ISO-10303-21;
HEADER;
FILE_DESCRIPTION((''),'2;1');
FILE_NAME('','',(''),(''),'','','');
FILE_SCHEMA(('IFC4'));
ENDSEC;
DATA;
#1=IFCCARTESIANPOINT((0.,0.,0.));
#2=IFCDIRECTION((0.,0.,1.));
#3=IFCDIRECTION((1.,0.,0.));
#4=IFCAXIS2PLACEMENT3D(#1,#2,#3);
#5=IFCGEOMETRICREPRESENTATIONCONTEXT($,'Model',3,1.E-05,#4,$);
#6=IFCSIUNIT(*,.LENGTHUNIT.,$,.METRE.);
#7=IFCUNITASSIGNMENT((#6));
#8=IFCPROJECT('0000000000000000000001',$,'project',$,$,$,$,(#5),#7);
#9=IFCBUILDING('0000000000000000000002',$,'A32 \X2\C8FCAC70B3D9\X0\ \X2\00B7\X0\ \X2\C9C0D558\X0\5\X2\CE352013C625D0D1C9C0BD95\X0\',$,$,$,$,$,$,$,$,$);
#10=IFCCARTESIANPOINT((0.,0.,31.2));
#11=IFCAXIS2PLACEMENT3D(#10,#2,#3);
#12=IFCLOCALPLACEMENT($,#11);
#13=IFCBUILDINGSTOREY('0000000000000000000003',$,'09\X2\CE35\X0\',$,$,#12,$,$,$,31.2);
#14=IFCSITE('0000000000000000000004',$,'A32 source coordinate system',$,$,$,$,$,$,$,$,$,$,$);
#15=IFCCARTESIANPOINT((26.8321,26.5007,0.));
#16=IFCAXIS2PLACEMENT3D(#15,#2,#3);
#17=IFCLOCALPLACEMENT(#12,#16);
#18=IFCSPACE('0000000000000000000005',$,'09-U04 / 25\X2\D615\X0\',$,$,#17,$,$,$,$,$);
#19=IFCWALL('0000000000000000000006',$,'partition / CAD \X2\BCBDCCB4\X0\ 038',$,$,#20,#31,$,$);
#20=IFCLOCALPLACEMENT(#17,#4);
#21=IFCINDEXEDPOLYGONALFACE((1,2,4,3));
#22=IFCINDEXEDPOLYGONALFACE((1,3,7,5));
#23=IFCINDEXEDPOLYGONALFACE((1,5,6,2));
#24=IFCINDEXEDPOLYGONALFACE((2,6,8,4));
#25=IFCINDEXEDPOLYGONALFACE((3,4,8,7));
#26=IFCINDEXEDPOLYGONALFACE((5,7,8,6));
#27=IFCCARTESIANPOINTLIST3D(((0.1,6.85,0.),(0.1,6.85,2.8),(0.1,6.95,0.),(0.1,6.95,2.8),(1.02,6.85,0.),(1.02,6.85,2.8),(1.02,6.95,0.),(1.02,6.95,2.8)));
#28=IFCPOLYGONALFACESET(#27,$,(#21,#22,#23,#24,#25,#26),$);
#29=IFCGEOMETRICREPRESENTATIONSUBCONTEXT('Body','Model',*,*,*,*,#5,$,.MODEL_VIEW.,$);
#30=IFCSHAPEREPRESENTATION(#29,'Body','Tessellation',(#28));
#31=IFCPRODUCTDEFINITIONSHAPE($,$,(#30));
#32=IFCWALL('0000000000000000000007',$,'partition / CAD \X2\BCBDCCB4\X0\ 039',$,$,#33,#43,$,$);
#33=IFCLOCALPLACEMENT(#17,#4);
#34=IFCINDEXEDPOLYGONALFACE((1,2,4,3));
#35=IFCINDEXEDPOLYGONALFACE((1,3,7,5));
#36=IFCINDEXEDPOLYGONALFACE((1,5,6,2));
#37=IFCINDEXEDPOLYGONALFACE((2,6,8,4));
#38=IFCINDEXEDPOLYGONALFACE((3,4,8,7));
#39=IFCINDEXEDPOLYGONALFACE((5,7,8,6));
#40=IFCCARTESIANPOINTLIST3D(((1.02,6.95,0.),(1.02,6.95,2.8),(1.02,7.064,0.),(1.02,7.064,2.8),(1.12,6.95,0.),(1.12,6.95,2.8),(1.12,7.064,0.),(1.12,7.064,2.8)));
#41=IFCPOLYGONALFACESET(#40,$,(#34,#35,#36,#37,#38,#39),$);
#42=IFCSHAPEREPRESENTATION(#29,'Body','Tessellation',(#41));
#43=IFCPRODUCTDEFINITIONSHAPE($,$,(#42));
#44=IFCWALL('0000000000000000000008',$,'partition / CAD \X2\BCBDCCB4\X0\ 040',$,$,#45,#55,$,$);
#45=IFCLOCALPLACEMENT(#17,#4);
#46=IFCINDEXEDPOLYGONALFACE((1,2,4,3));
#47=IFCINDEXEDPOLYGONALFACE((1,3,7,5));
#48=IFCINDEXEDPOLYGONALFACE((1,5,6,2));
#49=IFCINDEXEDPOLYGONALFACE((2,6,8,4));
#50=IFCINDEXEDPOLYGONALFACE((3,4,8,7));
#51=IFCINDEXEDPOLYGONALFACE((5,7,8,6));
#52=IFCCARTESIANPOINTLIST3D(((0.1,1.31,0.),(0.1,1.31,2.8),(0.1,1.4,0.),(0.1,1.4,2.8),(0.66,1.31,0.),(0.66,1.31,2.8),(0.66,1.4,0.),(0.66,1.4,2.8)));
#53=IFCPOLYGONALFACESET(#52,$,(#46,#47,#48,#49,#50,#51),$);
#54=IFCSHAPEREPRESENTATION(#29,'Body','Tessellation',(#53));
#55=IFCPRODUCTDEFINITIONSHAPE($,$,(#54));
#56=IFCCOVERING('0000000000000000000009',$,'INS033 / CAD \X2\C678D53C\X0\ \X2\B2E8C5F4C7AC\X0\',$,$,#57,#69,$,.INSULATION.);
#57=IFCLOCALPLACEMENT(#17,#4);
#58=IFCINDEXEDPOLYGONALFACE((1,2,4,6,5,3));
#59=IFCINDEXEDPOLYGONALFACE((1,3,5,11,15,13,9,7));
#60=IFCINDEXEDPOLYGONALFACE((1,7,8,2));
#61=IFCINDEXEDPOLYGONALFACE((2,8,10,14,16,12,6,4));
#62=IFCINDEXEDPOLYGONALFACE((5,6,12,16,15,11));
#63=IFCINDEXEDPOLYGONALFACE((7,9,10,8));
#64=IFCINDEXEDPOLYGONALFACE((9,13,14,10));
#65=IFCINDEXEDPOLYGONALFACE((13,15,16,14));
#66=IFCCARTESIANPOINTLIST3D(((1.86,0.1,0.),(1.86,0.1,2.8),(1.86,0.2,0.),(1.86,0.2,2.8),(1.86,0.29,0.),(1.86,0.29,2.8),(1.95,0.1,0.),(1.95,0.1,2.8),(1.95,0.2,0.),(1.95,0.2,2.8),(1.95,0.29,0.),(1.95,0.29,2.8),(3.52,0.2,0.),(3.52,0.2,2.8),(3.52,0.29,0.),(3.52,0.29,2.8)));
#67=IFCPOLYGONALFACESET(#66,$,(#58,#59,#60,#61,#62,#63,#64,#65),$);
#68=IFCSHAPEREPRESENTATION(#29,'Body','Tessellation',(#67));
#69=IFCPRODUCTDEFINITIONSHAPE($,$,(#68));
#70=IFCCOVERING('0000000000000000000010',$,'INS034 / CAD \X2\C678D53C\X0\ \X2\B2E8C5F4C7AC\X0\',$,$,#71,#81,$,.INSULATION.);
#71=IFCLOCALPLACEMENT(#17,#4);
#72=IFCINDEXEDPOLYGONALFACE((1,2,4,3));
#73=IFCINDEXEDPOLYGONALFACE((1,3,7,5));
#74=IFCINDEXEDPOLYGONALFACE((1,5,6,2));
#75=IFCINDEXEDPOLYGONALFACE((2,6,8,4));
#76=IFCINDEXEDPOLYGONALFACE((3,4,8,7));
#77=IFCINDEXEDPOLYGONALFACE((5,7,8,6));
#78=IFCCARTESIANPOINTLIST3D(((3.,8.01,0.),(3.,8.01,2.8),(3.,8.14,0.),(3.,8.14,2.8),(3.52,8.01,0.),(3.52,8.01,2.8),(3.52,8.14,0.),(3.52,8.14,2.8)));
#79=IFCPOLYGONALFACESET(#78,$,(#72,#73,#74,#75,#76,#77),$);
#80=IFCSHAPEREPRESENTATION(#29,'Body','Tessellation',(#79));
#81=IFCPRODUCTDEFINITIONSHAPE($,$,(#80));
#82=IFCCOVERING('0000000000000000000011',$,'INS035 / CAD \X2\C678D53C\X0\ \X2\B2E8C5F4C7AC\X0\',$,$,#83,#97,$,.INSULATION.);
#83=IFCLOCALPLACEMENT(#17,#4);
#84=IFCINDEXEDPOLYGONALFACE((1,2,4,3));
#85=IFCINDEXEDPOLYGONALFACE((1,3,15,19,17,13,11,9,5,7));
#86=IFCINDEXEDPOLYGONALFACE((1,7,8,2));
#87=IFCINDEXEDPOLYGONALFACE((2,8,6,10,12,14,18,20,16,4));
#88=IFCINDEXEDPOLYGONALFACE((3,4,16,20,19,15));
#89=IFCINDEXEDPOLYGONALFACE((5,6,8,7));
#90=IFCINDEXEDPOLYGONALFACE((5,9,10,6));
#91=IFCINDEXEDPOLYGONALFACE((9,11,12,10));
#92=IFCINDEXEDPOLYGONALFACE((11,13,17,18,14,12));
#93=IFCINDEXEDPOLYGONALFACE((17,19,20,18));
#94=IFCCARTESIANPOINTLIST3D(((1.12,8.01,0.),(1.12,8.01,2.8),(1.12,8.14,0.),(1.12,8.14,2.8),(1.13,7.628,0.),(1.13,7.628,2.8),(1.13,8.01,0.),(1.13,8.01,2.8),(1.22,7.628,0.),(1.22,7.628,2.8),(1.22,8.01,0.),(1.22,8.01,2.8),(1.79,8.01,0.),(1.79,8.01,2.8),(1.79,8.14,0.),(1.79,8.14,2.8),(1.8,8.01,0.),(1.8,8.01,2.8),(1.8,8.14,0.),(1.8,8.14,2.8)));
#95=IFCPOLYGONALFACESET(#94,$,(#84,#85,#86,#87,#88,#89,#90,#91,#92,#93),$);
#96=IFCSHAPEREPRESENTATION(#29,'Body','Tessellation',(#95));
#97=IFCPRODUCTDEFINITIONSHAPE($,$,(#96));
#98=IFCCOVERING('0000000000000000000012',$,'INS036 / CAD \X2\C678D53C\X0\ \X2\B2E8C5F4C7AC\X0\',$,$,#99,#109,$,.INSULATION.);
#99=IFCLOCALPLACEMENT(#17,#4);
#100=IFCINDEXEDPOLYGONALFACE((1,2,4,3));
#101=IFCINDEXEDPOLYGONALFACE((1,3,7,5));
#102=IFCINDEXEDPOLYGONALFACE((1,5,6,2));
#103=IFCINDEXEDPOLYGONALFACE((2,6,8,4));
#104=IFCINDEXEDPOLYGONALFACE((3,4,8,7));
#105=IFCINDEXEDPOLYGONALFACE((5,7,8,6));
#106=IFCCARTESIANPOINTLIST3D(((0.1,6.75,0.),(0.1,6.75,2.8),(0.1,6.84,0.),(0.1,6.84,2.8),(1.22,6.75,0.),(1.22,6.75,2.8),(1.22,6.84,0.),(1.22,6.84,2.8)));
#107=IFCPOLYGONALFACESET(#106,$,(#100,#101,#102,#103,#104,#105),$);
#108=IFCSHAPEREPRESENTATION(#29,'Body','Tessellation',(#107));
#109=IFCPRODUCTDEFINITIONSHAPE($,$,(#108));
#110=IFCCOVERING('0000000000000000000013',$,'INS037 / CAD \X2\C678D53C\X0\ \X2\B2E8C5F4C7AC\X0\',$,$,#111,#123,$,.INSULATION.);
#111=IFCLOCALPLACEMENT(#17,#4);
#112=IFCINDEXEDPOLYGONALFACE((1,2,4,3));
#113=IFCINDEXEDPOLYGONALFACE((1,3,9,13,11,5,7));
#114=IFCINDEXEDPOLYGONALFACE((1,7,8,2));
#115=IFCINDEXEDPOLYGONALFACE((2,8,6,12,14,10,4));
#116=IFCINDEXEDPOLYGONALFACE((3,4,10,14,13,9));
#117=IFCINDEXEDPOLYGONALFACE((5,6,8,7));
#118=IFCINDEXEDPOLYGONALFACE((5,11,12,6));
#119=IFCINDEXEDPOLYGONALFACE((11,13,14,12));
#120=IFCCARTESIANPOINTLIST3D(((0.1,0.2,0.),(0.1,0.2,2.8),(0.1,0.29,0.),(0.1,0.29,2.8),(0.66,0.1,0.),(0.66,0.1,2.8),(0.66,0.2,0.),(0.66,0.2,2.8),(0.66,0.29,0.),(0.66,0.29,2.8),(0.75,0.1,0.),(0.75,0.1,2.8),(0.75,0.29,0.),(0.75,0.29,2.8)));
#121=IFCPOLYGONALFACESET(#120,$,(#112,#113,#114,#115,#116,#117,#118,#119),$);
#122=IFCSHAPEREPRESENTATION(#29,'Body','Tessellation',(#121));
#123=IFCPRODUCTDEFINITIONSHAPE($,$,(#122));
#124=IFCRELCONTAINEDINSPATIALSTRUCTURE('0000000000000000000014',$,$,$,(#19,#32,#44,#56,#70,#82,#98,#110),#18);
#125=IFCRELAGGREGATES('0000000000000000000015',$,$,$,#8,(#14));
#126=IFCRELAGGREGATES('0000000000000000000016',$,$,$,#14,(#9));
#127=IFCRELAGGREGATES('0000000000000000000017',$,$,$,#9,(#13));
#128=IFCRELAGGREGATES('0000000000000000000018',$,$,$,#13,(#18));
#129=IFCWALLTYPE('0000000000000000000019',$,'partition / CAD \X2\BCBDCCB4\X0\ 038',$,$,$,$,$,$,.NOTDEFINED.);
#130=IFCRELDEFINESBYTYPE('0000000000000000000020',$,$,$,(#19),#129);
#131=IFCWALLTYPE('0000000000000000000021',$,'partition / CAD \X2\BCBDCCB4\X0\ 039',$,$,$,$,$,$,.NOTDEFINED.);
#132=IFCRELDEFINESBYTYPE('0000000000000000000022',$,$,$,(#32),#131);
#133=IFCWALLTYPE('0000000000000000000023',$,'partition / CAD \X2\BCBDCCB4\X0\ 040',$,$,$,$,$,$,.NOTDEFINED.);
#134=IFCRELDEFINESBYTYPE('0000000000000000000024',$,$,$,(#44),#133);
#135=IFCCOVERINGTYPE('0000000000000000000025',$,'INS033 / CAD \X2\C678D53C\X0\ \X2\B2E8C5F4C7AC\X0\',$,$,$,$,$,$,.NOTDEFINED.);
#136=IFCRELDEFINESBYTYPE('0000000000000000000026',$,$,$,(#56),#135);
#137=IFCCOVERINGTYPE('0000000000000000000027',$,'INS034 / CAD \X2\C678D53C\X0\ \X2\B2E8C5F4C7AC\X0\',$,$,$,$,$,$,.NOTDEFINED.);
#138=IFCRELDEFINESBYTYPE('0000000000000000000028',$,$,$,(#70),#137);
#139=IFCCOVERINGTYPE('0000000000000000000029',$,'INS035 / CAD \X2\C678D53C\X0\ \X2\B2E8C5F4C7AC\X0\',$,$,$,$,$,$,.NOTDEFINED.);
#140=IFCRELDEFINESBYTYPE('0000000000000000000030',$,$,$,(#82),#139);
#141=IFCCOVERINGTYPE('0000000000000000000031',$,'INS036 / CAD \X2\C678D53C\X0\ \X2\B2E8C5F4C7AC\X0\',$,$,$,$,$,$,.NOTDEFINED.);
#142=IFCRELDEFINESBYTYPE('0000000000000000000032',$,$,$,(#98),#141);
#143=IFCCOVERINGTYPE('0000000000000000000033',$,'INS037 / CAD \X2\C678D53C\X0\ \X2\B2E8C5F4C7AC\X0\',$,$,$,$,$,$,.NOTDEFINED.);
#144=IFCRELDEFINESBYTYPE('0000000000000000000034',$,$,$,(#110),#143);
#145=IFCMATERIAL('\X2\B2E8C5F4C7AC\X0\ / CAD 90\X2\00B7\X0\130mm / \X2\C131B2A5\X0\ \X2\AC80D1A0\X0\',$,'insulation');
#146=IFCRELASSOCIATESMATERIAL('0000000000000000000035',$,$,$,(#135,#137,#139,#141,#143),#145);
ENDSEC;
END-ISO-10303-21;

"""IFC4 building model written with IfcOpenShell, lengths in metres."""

from ifc_helpers import new_model, si_unit, frame, origin, origin_with_axes, place, context, subcontext, project, spatial, polyline, outline, extrude, source, transform, mapped, material, type_object, type_shapes, element, save


model = new_model("IFC4")

# Units and contexts
model_context = context("Model", 3, precision=1e-05, world=origin_with_axes())
body_context = subcontext(model_context, "Body", "Model", "MODEL_VIEW")
ifc_project = project(units=[si_unit("LENGTHUNIT", "METRE")], contexts=[model_context])

# Site, building, storey, space
storey_placement = place(None, frame((0.0, 0.0, 31.2), z_axis=(0.0, 0.0, 1.0), x_axis=(1.0, 0.0, 0.0)))
space_placement = place(storey_placement, frame((26.8321, 26.5007, 0.0), z_axis=(0.0, 0.0, 1.0), x_axis=(1.0, 0.0, 0.0)))
site = spatial("IfcSite", under=ifc_project, Name="A32 source coordinate system")
building = spatial("IfcBuilding", under=site, Name="A32 주거동 · 지하5층–옥탑지붕")
storey = spatial("IfcBuildingStorey", under=building, at=storey_placement, Name="09층", Elevation=31.2)
space = spatial("IfcSpace", under=storey, at=space_placement, Name="09-U04 / 25형")

# Walls
wall_type_1 = type_object("IfcWallType", Name="partition / CAD 벽체 038", PredefinedType="NOTDEFINED")
shared_shape_1 = source(origin(), body_context, "Body", "SweptSolid", [
    extrude(outline(polyline([(0.1, 6.95), (1.02, 6.95), (1.02, 6.85), (0.1, 6.85), (0.1, 6.95)])), origin(), (0.0, 0.0, 1.0), 2.8),
])
type_shapes(wall_type_1, [shared_shape_1])
wall_1_placement = place(space_placement, origin_with_axes())
element("IfcWall", 1, at=wall_1_placement, inside=space, type_object=wall_type_1, Name="partition / CAD 벽체 038", context=body_context, shape_type="MappedRepresentation", body=[
    mapped(shared_shape_1, transform((0.0, 0.0, 0.0), scale=1.0)),
])
wall_type_2 = type_object("IfcWallType", Name="partition / CAD 벽체 039", PredefinedType="NOTDEFINED")
shared_shape_2 = source(origin(), body_context, "Body", "SweptSolid", [
    extrude(outline(polyline([(1.02, 6.95), (1.02, 7.064), (1.12, 7.064), (1.12, 6.95), (1.02, 6.95)])), origin(), (0.0, 0.0, 1.0), 2.8),
])
type_shapes(wall_type_2, [shared_shape_2])
wall_2_placement = place(space_placement, origin_with_axes())
element("IfcWall", 2, at=wall_2_placement, inside=space, type_object=wall_type_2, Name="partition / CAD 벽체 039", context=body_context, shape_type="MappedRepresentation", body=[
    mapped(shared_shape_2, transform((0.0, 0.0, 0.0), scale=1.0)),
])
wall_type_3 = type_object("IfcWallType", Name="partition / CAD 벽체 040", PredefinedType="NOTDEFINED")
shared_shape_3 = source(origin(), body_context, "Body", "SweptSolid", [
    extrude(outline(polyline([(0.1, 1.4), (0.66, 1.4), (0.66, 1.31), (0.1, 1.31), (0.1, 1.4)])), origin(), (0.0, 0.0, 1.0), 2.8),
])
type_shapes(wall_type_3, [shared_shape_3])
wall_3_placement = place(space_placement, origin_with_axes())
element("IfcWall", 3, at=wall_3_placement, inside=space, type_object=wall_type_3, Name="partition / CAD 벽체 040", context=body_context, shape_type="MappedRepresentation", body=[
    mapped(shared_shape_3, transform((0.0, 0.0, 0.0), scale=1.0)),
])

# Coverings
ifc_material = material(Name="단열재 / CAD 90·130mm / 성능 검토", Category="insulation")
covering_type_1 = type_object("IfcCoveringType", Name="INS033 / CAD 외피 단열재", PredefinedType="NOTDEFINED", material=ifc_material)
shared_shape_4 = source(origin(), body_context, "Body", "SweptSolid", [
    extrude(outline(polyline([(1.95, 0.29), (3.52, 0.29), (3.52, 0.2), (1.95, 0.2), (1.95, 0.1), (1.86, 0.1), (1.86, 0.2), (1.86, 0.29), (1.95, 0.29)])), origin(), (0.0, 0.0, 1.0), 2.8),
])
type_shapes(covering_type_1, [shared_shape_4])
covering_1_placement = place(space_placement, origin_with_axes())
element("IfcCovering", 4, at=covering_1_placement, inside=space, type_object=covering_type_1, Name="INS033 / CAD 외피 단열재", PredefinedType="INSULATION", context=body_context, shape_type="MappedRepresentation", body=[
    mapped(shared_shape_4, transform((0.0, 0.0, 0.0), scale=1.0)),
])
covering_type_2 = type_object("IfcCoveringType", Name="INS034 / CAD 외피 단열재", PredefinedType="NOTDEFINED", material=ifc_material)
shared_shape_5 = source(origin(), body_context, "Body", "SweptSolid", [
    extrude(outline(polyline([(3.52, 8.01), (3.0, 8.01), (3.0, 8.14), (3.52, 8.14), (3.52, 8.01)])), origin(), (0.0, 0.0, 1.0), 2.8),
])
type_shapes(covering_type_2, [shared_shape_5])
covering_2_placement = place(space_placement, origin_with_axes())
element("IfcCovering", 5, at=covering_2_placement, inside=space, type_object=covering_type_2, Name="INS034 / CAD 외피 단열재", PredefinedType="INSULATION", context=body_context, shape_type="MappedRepresentation", body=[
    mapped(shared_shape_5, transform((0.0, 0.0, 0.0), scale=1.0)),
])
covering_type_3 = type_object("IfcCoveringType", Name="INS035 / CAD 외피 단열재", PredefinedType="NOTDEFINED", material=ifc_material)
shared_shape_6 = source(origin(), body_context, "Body", "SweptSolid", [
    extrude(outline(polyline([(1.8, 8.01), (1.79, 8.01), (1.22, 8.01), (1.22, 7.628), (1.13, 7.628), (1.13, 8.01), (1.12, 8.01), (1.12, 8.14), (1.79, 8.14), (1.8, 8.14), (1.8, 8.01)])), origin(), (0.0, 0.0, 1.0), 2.8),
])
type_shapes(covering_type_3, [shared_shape_6])
covering_3_placement = place(space_placement, origin_with_axes())
element("IfcCovering", 6, at=covering_3_placement, inside=space, type_object=covering_type_3, Name="INS035 / CAD 외피 단열재", PredefinedType="INSULATION", context=body_context, shape_type="MappedRepresentation", body=[
    mapped(shared_shape_6, transform((0.0, 0.0, 0.0), scale=1.0)),
])
covering_type_4 = type_object("IfcCoveringType", Name="INS036 / CAD 외피 단열재", PredefinedType="NOTDEFINED", material=ifc_material)
shared_shape_7 = source(origin(), body_context, "Body", "SweptSolid", [
    extrude(outline(polyline([(1.22, 6.84), (1.22, 6.75), (0.1, 6.75), (0.1, 6.84), (1.22, 6.84)])), origin(), (0.0, 0.0, 1.0), 2.8),
])
type_shapes(covering_type_4, [shared_shape_7])
covering_4_placement = place(space_placement, origin_with_axes())
element("IfcCovering", 7, at=covering_4_placement, inside=space, type_object=covering_type_4, Name="INS036 / CAD 외피 단열재", PredefinedType="INSULATION", context=body_context, shape_type="MappedRepresentation", body=[
    mapped(shared_shape_7, transform((0.0, 0.0, 0.0), scale=1.0)),
])
covering_type_5 = type_object("IfcCoveringType", Name="INS037 / CAD 외피 단열재", PredefinedType="NOTDEFINED", material=ifc_material)
shared_shape_8 = source(origin(), body_context, "Body", "SweptSolid", [
    extrude(outline(polyline([(0.1, 0.2), (0.1, 0.29), (0.66, 0.29), (0.75, 0.29), (0.75, 0.1), (0.66, 0.1), (0.66, 0.2), (0.1, 0.2)])), origin(), (0.0, 0.0, 1.0), 2.8),
])
type_shapes(covering_type_5, [shared_shape_8])
covering_5_placement = place(space_placement, origin_with_axes())
element("IfcCovering", 8, at=covering_5_placement, inside=space, type_object=covering_type_5, Name="INS037 / CAD 외피 단열재", PredefinedType="INSULATION", context=body_context, shape_type="MappedRepresentation", body=[
    mapped(shared_shape_8, transform((0.0, 0.0, 0.0), scale=1.0)),
])

save(model, "model.ifc")
